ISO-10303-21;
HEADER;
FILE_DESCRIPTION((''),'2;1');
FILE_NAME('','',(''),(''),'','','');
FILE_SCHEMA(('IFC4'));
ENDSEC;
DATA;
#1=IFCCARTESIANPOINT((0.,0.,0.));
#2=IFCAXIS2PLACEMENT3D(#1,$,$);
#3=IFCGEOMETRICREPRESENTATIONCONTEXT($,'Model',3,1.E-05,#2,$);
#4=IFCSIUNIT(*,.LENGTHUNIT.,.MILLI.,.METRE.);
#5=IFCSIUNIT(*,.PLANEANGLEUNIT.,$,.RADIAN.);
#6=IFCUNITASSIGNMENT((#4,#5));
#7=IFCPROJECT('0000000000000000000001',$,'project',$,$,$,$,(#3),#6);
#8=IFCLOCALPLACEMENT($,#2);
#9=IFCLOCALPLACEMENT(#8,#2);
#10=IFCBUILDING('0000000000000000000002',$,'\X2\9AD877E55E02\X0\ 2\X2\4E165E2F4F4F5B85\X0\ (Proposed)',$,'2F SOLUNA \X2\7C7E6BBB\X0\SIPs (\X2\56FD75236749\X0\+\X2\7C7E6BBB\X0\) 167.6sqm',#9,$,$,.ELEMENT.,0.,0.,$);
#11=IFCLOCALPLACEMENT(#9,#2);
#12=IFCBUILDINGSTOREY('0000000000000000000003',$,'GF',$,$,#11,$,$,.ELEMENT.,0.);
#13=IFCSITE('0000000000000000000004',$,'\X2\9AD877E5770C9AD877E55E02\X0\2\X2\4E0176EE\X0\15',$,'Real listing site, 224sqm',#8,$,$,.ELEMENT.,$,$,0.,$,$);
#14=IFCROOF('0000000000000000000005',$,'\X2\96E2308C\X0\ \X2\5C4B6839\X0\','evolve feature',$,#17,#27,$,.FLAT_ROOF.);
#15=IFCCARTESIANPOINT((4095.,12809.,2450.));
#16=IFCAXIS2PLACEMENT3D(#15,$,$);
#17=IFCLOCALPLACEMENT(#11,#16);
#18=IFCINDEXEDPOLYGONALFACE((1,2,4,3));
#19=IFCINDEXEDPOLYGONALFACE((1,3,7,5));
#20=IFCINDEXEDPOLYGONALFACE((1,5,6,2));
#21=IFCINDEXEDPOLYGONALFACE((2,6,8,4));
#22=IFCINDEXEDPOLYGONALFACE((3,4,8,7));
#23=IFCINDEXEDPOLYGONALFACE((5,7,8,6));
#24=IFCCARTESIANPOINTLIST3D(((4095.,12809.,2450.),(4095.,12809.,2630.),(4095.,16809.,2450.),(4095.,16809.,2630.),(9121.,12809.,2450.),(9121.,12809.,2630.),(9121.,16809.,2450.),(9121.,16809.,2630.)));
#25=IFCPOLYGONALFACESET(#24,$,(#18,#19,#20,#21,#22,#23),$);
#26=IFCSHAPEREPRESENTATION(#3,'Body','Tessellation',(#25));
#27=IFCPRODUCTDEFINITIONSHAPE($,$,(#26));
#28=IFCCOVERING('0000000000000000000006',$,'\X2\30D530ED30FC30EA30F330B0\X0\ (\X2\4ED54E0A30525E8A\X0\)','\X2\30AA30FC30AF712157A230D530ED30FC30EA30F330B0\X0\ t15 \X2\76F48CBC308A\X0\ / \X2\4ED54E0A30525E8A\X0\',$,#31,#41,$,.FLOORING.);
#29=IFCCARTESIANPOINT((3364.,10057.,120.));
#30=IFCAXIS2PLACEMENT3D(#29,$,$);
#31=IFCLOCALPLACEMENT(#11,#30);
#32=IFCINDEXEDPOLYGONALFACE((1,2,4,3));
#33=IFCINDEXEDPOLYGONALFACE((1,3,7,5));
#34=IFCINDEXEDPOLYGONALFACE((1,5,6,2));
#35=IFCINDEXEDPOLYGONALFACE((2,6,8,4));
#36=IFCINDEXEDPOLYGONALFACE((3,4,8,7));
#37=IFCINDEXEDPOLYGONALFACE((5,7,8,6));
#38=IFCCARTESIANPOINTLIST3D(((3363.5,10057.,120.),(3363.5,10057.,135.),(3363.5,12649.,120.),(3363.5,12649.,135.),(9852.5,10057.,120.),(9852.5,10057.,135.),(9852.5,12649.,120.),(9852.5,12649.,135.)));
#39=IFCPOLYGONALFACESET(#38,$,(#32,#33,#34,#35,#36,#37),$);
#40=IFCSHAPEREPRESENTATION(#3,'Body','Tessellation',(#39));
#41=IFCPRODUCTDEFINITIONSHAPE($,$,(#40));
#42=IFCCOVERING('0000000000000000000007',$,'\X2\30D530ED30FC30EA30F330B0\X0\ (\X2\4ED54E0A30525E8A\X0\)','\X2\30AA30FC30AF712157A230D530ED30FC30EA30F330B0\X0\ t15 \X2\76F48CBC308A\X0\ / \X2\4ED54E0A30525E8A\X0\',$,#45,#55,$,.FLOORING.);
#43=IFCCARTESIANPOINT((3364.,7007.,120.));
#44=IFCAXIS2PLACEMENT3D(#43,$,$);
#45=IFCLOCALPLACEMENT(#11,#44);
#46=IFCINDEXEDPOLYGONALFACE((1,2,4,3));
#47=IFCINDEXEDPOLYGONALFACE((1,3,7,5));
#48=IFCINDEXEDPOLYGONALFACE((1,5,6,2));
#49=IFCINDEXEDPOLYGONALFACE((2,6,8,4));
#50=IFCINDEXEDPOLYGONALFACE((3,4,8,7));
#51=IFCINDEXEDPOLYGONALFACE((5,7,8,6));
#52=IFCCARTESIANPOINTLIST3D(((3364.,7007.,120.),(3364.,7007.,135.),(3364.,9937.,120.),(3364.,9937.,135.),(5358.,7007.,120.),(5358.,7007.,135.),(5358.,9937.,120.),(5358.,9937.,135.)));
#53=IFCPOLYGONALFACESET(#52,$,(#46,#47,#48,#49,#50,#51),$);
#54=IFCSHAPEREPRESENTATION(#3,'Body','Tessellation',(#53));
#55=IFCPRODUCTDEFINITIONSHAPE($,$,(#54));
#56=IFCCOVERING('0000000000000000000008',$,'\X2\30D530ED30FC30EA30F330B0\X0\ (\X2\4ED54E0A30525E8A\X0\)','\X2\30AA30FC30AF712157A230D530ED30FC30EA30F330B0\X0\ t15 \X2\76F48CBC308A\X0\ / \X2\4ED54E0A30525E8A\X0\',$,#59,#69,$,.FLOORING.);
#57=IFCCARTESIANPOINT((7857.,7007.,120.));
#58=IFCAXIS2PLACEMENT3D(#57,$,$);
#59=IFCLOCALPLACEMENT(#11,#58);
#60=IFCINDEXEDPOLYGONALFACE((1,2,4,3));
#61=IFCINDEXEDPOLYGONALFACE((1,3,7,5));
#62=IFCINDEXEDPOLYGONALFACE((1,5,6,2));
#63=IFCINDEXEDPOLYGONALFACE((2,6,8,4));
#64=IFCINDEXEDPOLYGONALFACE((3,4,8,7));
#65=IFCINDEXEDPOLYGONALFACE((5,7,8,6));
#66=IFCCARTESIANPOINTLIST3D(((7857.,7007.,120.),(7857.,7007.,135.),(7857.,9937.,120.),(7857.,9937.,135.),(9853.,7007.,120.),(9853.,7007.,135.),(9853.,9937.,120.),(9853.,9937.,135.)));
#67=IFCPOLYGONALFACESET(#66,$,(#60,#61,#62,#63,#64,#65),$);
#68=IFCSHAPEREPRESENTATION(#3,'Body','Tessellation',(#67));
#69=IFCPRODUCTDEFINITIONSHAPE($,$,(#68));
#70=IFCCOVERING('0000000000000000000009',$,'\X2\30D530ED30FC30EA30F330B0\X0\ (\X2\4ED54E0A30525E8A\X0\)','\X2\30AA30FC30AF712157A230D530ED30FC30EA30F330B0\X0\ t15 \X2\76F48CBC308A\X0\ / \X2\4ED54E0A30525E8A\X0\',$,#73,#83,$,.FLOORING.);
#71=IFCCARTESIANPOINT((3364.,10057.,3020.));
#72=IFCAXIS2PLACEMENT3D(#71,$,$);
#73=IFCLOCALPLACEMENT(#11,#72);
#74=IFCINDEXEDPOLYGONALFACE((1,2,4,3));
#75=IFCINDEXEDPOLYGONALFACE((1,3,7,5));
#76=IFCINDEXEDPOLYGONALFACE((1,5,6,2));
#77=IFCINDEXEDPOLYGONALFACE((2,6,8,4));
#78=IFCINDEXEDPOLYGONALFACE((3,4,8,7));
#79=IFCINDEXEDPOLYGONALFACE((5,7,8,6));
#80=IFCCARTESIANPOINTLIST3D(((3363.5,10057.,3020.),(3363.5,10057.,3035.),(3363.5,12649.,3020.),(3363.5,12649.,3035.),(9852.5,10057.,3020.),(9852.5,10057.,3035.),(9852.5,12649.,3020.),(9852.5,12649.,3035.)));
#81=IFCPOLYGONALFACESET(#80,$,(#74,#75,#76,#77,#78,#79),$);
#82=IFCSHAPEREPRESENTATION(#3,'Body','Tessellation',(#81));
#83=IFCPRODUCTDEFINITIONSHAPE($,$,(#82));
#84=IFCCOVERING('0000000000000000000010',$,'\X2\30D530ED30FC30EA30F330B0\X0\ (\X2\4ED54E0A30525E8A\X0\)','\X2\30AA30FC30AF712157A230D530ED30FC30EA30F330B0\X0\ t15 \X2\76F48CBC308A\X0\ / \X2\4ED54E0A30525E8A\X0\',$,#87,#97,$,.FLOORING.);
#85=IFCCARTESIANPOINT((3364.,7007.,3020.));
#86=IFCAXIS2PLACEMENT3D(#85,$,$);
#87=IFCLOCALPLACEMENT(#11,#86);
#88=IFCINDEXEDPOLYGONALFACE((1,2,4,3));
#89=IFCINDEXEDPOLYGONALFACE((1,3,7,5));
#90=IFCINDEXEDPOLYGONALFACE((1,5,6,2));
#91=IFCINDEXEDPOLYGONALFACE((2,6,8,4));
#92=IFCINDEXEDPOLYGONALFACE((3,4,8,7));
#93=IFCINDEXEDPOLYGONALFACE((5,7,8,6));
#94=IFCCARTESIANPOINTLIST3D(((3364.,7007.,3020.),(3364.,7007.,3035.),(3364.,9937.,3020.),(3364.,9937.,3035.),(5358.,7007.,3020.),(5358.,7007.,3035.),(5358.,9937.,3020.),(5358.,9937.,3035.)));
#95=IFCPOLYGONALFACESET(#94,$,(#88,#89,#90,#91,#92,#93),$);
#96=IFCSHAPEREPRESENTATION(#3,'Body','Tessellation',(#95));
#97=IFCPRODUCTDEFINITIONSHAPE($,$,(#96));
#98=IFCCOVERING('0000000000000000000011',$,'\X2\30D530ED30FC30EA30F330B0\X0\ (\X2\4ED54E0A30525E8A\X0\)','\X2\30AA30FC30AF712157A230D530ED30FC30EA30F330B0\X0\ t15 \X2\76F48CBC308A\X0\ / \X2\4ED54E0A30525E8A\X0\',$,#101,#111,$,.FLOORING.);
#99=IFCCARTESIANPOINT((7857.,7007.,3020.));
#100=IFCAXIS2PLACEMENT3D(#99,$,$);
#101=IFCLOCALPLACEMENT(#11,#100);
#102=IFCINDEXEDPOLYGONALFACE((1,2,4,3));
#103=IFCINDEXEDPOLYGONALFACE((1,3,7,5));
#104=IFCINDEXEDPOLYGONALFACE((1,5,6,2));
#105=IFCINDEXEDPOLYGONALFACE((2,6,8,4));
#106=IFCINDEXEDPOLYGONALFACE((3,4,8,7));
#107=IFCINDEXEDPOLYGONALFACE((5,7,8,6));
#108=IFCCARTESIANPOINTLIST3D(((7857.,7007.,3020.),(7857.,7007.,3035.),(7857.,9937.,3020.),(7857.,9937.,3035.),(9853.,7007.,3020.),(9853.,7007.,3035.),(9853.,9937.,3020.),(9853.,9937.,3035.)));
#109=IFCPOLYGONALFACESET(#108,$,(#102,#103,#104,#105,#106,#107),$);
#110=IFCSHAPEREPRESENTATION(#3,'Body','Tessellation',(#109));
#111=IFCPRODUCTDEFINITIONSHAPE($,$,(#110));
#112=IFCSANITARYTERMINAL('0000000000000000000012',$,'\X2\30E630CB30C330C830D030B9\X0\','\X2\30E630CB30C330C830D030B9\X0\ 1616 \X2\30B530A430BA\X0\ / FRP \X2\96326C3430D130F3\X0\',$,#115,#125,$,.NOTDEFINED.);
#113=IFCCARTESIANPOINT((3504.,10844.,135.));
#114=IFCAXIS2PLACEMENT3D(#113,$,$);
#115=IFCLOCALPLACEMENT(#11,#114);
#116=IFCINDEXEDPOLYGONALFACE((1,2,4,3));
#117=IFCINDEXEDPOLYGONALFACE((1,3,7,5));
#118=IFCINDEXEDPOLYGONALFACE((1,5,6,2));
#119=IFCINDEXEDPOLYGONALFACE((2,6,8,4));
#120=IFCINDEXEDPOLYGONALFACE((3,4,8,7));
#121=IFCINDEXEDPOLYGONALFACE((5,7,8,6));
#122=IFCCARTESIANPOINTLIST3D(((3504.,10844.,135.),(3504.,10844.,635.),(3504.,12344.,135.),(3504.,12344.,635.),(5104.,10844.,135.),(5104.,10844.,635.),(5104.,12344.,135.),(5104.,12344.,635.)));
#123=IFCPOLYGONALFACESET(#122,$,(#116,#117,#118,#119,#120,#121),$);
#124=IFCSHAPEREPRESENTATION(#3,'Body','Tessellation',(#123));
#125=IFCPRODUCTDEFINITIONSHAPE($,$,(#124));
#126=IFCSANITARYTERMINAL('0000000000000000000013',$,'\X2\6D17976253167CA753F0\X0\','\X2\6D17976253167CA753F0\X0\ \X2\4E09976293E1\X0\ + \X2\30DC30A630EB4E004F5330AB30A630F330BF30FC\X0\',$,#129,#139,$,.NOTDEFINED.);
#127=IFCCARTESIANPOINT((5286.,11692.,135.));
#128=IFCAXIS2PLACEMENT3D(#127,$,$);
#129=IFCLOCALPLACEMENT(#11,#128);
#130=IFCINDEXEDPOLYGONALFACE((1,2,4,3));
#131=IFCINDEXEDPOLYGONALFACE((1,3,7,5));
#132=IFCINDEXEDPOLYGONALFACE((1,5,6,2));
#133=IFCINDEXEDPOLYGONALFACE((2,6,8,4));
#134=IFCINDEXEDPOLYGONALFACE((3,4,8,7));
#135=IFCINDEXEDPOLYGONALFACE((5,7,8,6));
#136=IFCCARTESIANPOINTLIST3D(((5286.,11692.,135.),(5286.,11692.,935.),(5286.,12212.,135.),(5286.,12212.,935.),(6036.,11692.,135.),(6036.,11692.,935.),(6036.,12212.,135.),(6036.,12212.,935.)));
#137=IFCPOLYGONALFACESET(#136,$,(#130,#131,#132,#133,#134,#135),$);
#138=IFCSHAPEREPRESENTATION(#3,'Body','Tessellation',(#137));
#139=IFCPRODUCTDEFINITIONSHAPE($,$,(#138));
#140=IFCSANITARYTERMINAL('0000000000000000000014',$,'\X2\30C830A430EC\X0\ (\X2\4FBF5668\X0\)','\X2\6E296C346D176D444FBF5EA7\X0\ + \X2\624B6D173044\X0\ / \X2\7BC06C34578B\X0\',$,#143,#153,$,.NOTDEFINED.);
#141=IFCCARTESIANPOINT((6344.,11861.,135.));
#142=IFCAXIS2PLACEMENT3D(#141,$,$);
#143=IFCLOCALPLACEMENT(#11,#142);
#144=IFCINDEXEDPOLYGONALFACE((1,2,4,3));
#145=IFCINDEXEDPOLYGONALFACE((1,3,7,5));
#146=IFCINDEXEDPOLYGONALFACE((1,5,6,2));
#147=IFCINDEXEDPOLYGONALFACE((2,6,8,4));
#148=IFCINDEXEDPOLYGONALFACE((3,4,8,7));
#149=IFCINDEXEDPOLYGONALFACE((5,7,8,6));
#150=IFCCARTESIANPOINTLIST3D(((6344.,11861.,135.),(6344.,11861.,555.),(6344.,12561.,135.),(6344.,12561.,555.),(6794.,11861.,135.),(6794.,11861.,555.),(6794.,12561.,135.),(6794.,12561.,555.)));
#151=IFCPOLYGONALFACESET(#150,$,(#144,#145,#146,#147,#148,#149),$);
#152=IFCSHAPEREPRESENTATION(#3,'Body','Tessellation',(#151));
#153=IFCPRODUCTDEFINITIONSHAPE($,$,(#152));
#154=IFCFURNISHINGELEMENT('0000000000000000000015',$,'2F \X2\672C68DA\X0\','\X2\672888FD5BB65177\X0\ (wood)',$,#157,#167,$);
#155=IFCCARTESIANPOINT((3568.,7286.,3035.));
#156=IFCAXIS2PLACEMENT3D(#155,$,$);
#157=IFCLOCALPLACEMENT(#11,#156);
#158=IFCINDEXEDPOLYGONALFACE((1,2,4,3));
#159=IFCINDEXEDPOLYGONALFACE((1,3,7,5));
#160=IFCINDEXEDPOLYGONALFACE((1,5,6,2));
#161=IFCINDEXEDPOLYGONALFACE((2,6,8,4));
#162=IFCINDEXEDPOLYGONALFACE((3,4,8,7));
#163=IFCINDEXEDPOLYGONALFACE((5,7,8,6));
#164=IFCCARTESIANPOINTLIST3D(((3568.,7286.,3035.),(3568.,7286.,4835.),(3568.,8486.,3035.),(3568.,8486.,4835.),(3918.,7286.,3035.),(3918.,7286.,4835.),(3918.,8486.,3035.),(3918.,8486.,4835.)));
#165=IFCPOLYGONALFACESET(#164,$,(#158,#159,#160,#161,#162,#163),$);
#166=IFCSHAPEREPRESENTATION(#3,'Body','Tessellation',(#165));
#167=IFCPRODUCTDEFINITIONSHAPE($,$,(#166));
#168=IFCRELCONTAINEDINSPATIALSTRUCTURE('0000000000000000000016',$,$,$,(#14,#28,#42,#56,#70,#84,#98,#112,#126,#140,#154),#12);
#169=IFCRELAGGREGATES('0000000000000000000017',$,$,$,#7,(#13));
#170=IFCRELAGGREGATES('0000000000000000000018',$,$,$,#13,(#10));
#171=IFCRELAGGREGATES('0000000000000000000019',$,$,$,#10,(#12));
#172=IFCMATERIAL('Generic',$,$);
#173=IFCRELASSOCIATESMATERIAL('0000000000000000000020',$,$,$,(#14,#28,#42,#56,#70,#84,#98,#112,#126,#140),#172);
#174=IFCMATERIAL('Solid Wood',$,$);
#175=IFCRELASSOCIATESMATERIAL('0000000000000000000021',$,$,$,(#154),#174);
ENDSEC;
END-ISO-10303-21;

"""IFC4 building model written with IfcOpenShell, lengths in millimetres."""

from ifc_helpers import new_model, si_unit, frame, frame_2d, origin, place, context, project, spatial, rectangle, extrude, material, element, save


model = new_model("IFC4")

# Units and contexts
model_context = context("Model", 3, precision=1e-05, world=origin())
ifc_project = project(units=[si_unit("LENGTHUNIT", "METRE", prefix="MILLI"), si_unit("PLANEANGLEUNIT", "RADIAN")], contexts=[model_context])

# Site, building, storey
site_placement = place(None, origin())
site = spatial("IfcSite", under=ifc_project, at=site_placement, Name="高知県高知市2丁目15", ObjectType="Real listing site, 224sqm", CompositionType="ELEMENT", RefElevation=0.0)
building_placement = place(site_placement, origin())
building = spatial("IfcBuilding", under=site, at=building_placement, Name="高知市 2世帯住宅 (Proposed)", ObjectType="2F SOLUNA 籾殻SIPs (国産杉+籾殻) 167.6sqm", CompositionType="ELEMENT", ElevationOfRefHeight=0.0, ElevationOfTerrain=0.0)
storey_placement = place(building_placement, origin())
storey = spatial("IfcBuildingStorey", under=building, at=storey_placement, Name="GF", CompositionType="ELEMENT", Elevation=0.0)

# Shared definitions
ifc_material_1 = material(Name="Solid Wood")
ifc_material_2 = material(Name="Generic")

# Roof
roof_1_placement = place(storey_placement, frame((4095.0, 12809.0, 2450.0)))
element("IfcRoof", 1, at=roof_1_placement, inside=storey, material=ifc_material_2, Name="離れ 屋根", Description="evolve feature", PredefinedType="FLAT_ROOF", context=model_context, shape_type="SweptSolid", body=[
    extrude(rectangle(XDim=5026.0, YDim=4000.0, at=frame_2d((2513.0, 2000.0))), frame((4095.0, 12809.0, 2450.0)), (0.0, 0.0, 1.0), 180.0),
])

# Coverings
covering_1_placement = place(storey_placement, frame((3364.0, 10057.0, 120.0)))
element("IfcCovering", 2, at=covering_1_placement, inside=storey, material=ifc_material_2, Name="フローリング (仕上げ床)", Description="オーク無垢フローリング t15 直貼り / 仕上げ床", PredefinedType="FLOORING", context=model_context, shape_type="SweptSolid", body=[
    extrude(rectangle(XDim=6489.0, YDim=2592.0, at=frame_2d((3244.0, 1296.0))), frame((3364.0, 10057.0, 120.0)), (0.0, 0.0, 1.0), 15.0),
])
covering_2_placement = place(storey_placement, frame((3364.0, 7007.0, 120.0)))
element("IfcCovering", 3, at=covering_2_placement, inside=storey, material=ifc_material_2, Name="フローリング (仕上げ床)", Description="オーク無垢フローリング t15 直貼り / 仕上げ床", PredefinedType="FLOORING", context=model_context, shape_type="SweptSolid", body=[
    extrude(rectangle(XDim=1994.0, YDim=2930.0, at=frame_2d((997.0, 1465.0))), frame((3364.0, 7007.0, 120.0)), (0.0, 0.0, 1.0), 15.0),
])
covering_3_placement = place(storey_placement, frame((7857.0, 7007.0, 120.0)))
element("IfcCovering", 4, at=covering_3_placement, inside=storey, material=ifc_material_2, Name="フローリング (仕上げ床)", Description="オーク無垢フローリング t15 直貼り / 仕上げ床", PredefinedType="FLOORING", context=model_context, shape_type="SweptSolid", body=[
    extrude(rectangle(XDim=1996.0, YDim=2930.0, at=frame_2d((998.0, 1465.0))), frame((7857.0, 7007.0, 120.0)), (0.0, 0.0, 1.0), 15.0),
])
covering_4_placement = place(storey_placement, frame((3364.0, 10057.0, 3020.0)))
element("IfcCovering", 5, at=covering_4_placement, inside=storey, material=ifc_material_2, Name="フローリング (仕上げ床)", Description="オーク無垢フローリング t15 直貼り / 仕上げ床", PredefinedType="FLOORING", context=model_context, shape_type="SweptSolid", body=[
    extrude(rectangle(XDim=6489.0, YDim=2592.0, at=frame_2d((3244.0, 1296.0))), frame((3364.0, 10057.0, 3020.0)), (0.0, 0.0, 1.0), 15.0),
])
covering_5_placement = place(storey_placement, frame((3364.0, 7007.0, 3020.0)))
element("IfcCovering", 6, at=covering_5_placement, inside=storey, material=ifc_material_2, Name="フローリング (仕上げ床)", Description="オーク無垢フローリング t15 直貼り / 仕上げ床", PredefinedType="FLOORING", context=model_context, shape_type="SweptSolid", body=[
    extrude(rectangle(XDim=1994.0, YDim=2930.0, at=frame_2d((997.0, 1465.0))), frame((3364.0, 7007.0, 3020.0)), (0.0, 0.0, 1.0), 15.0),
])
covering_6_placement = place(storey_placement, frame((7857.0, 7007.0, 3020.0)))
element("IfcCovering", 7, at=covering_6_placement, inside=storey, material=ifc_material_2, Name="フローリング (仕上げ床)", Description="オーク無垢フローリング t15 直貼り / 仕上げ床", PredefinedType="FLOORING", context=model_context, shape_type="SweptSolid", body=[
    extrude(rectangle(XDim=1996.0, YDim=2930.0, at=frame_2d((998.0, 1465.0))), frame((7857.0, 7007.0, 3020.0)), (0.0, 0.0, 1.0), 15.0),
])

# Sanitary terminals
sanitary_terminal_1_placement = place(storey_placement, frame((3504.0, 10844.0, 135.0)))
element("IfcSanitaryTerminal", 8, at=sanitary_terminal_1_placement, inside=storey, material=ifc_material_2, Name="ユニットバス", Description="ユニットバス 1616 サイズ / FRP 防水パン", PredefinedType="NOTDEFINED", context=model_context, shape_type="SweptSolid", body=[
    extrude(rectangle(XDim=1600.0, YDim=1500.0, at=frame_2d((800.0, 750.0))), frame((3504.0, 10844.0, 135.0)), (0.0, 0.0, 1.0), 500.0),
])
sanitary_terminal_2_placement = place(storey_placement, frame((5286.0, 11692.0, 135.0)))
element("IfcSanitaryTerminal", 9, at=sanitary_terminal_2_placement, inside=storey, material=ifc_material_2, Name="洗面化粧台", Description="洗面化粧台 三面鏡 + ボウル一体カウンター", PredefinedType="NOTDEFINED", context=model_context, shape_type="SweptSolid", body=[
    extrude(rectangle(XDim=750.0, YDim=520.0, at=frame_2d((375.0, 260.0))), frame((5286.0, 11692.0, 135.0)), (0.0, 0.0, 1.0), 800.0),
])
sanitary_terminal_3_placement = place(storey_placement, frame((6344.0, 11861.0, 135.0)))
element("IfcSanitaryTerminal", 10, at=sanitary_terminal_3_placement, inside=storey, material=ifc_material_2, Name="トイレ (便器)", Description="温水洗浄便座 + 手洗い / 節水型", PredefinedType="NOTDEFINED", context=model_context, shape_type="SweptSolid", body=[
    extrude(rectangle(XDim=450.0, YDim=700.0, at=frame_2d((225.0, 350.0))), frame((6344.0, 11861.0, 135.0)), (0.0, 0.0, 1.0), 420.0),
])

# Furnishing element
furnishing_placement = place(storey_placement, frame((3568.0, 7286.0, 3035.0)))
element("IfcFurnishingElement", 11, at=furnishing_placement, inside=storey, material=ifc_material_1, Name="2F 本棚", Description="木製家具 (wood)", context=model_context, shape_type="SweptSolid", body=[
    extrude(rectangle(XDim=350.0, YDim=1200.0, at=frame_2d((175.0, 600.0))), frame((3568.0, 7286.0, 3035.0)), (0.0, 0.0, 1.0), 1800.0),
])

save(model, "model.ifc")
